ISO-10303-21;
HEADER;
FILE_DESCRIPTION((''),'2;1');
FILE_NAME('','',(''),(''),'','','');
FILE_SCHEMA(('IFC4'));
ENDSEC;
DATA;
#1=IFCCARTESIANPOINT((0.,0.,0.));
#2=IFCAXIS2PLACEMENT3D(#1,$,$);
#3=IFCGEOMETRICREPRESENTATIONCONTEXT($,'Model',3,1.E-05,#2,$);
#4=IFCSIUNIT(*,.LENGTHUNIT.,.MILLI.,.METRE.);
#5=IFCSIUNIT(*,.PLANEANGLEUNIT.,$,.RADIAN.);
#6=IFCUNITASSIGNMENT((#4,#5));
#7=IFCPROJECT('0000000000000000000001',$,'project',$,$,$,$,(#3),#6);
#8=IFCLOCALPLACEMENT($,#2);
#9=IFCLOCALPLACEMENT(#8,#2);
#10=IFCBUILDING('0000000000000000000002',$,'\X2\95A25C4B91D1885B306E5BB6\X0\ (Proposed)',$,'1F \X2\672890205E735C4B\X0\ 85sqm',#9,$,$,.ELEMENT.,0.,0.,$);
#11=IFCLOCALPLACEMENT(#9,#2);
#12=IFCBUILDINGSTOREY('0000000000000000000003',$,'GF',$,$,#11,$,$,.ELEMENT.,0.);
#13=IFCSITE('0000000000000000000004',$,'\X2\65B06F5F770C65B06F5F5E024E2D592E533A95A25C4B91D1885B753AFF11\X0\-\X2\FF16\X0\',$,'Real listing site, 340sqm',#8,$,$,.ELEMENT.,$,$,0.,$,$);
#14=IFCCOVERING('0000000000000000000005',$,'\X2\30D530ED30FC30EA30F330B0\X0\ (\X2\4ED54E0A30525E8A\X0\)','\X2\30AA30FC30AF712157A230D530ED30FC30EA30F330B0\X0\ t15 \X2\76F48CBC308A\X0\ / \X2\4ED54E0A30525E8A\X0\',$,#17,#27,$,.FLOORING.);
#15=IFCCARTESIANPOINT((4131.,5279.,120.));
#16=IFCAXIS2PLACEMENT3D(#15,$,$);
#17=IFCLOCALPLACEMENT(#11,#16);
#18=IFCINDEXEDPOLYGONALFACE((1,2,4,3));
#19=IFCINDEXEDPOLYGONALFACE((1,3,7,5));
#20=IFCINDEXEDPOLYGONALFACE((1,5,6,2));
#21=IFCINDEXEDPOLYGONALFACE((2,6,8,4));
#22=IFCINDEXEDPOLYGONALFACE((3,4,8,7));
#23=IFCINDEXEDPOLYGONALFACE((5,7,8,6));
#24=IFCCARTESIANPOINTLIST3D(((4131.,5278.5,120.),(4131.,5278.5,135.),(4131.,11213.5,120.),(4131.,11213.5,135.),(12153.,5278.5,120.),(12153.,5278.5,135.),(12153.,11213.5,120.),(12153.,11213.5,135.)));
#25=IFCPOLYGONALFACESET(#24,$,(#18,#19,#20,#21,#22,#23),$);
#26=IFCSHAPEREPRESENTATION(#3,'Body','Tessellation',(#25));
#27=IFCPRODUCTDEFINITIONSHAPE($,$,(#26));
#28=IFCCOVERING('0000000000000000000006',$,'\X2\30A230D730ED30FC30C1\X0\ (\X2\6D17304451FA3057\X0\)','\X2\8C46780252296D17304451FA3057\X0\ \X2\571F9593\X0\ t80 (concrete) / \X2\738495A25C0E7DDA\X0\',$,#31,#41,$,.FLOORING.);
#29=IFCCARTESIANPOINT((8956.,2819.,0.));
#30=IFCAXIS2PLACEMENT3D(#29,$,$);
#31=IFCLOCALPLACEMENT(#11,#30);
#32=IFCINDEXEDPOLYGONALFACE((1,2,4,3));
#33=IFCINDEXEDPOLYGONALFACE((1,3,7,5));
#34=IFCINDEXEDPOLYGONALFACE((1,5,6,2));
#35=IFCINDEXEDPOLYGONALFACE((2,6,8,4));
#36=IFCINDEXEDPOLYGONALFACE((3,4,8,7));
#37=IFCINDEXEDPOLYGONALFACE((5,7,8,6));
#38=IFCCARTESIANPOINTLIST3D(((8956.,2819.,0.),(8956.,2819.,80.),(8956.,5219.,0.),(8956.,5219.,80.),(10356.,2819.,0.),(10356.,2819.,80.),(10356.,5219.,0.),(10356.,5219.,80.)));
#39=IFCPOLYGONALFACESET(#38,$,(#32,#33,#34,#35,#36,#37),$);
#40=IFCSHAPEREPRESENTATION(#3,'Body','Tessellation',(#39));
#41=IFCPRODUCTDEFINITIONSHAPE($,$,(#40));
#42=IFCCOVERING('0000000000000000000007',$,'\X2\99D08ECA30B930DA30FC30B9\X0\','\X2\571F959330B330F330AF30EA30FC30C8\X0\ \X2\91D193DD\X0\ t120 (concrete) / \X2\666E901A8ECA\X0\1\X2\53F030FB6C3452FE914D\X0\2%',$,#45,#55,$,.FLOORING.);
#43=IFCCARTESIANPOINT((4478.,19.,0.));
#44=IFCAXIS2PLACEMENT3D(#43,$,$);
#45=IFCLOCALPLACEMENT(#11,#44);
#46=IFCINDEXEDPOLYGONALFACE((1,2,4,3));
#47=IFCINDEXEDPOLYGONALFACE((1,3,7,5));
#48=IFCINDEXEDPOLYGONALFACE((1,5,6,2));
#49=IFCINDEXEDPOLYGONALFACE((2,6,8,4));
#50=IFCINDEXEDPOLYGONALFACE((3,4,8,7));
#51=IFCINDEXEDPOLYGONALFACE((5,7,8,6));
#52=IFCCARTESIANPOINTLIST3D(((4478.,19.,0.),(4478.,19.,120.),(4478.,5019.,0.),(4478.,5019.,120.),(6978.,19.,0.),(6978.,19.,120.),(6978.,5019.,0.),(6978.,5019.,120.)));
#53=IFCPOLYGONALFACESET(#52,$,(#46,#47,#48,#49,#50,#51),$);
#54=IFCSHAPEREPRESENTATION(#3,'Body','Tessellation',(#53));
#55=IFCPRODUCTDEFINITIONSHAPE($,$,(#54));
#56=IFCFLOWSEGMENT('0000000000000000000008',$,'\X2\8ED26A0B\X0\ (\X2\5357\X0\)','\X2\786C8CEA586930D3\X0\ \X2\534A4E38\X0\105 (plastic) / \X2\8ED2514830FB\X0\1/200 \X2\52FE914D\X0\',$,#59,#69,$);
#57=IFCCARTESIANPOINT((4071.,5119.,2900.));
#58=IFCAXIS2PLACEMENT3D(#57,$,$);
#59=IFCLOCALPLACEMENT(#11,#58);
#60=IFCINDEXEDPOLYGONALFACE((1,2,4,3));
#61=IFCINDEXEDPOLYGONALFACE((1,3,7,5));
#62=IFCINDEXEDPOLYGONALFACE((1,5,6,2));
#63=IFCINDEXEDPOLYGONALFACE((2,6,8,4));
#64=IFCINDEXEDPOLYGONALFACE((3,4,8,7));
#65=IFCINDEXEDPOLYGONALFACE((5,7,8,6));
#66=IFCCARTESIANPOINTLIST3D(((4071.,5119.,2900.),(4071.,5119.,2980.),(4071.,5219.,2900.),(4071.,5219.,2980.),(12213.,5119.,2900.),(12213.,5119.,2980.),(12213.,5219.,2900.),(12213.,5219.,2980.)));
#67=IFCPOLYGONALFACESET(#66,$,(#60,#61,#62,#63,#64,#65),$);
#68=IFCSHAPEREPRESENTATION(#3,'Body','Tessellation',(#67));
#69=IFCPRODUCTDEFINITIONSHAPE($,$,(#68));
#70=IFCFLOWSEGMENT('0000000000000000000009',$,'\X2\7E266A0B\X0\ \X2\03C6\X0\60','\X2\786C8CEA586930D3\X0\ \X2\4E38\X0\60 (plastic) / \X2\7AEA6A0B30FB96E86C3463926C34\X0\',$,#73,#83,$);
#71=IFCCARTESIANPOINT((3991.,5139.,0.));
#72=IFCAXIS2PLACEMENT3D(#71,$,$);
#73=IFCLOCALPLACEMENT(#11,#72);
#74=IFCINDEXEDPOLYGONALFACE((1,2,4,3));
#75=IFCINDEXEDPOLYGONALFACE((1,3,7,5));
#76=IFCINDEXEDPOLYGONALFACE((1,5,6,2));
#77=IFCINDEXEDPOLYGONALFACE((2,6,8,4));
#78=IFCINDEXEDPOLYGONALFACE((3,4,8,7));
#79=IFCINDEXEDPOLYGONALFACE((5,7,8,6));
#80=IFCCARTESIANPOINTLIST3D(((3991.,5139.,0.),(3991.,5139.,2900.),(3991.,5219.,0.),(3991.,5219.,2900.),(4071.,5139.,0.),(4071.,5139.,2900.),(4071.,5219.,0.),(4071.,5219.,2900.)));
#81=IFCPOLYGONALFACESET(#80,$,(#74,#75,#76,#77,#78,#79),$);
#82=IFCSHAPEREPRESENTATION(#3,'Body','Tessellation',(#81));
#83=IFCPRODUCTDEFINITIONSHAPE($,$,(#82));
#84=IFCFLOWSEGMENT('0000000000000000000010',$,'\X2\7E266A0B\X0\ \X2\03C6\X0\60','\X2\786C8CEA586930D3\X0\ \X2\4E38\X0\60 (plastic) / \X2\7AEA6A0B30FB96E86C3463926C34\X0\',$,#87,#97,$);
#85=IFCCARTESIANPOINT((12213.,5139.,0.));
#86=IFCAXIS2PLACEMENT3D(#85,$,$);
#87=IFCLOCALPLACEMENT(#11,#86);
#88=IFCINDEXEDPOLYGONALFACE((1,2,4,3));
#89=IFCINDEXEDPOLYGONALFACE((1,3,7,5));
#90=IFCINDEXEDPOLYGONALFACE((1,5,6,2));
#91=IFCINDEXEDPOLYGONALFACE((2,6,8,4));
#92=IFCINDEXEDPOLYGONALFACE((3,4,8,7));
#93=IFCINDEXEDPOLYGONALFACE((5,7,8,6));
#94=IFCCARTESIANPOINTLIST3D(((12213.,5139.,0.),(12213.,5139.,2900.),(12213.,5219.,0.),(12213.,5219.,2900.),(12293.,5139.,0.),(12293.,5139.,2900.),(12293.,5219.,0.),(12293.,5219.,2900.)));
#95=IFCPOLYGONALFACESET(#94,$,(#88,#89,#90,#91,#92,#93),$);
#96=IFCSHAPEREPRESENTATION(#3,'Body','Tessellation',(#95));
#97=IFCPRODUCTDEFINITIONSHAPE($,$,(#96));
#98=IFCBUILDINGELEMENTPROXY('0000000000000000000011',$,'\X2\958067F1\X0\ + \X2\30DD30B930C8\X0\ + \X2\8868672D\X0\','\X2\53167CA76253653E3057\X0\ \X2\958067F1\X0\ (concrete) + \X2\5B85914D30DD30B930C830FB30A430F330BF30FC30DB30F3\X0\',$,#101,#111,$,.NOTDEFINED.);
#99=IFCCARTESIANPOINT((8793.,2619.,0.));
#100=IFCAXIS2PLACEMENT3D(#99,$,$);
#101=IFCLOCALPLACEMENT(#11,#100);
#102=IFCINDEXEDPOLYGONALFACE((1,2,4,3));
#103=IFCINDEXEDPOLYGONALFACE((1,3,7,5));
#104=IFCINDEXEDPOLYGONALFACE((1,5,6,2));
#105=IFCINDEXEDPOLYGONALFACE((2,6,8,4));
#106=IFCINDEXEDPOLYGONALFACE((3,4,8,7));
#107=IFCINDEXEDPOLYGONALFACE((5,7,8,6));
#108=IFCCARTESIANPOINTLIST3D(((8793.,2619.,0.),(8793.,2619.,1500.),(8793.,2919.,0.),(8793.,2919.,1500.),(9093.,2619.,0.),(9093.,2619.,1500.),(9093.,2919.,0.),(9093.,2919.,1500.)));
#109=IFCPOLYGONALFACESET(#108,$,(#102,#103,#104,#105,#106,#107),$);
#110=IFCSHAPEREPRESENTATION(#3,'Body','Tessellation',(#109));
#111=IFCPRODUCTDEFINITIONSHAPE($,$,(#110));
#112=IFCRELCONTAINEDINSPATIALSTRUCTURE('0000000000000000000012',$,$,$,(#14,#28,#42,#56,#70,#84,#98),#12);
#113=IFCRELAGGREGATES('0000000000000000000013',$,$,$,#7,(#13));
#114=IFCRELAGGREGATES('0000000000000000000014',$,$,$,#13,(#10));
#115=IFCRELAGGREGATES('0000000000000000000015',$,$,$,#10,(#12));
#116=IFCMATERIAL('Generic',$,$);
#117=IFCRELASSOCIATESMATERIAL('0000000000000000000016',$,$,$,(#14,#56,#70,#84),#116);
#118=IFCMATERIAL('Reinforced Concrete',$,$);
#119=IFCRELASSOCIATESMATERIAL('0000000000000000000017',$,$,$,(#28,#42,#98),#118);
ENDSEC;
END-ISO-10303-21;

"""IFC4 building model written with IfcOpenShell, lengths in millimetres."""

from ifc_helpers import new_model, si_unit, frame, frame_2d, origin, place, context, project, spatial, rectangle, extrude, material, element, save


model = new_model("IFC4")

# Units and contexts
model_context = context("Model", 3, precision=1e-05, world=origin())
ifc_project = project(units=[si_unit("LENGTHUNIT", "METRE", prefix="MILLI"), si_unit("PLANEANGLEUNIT", "RADIAN")], contexts=[model_context])

# Site, building, storey
site_placement = place(None, origin())
site = spatial("IfcSite", under=ifc_project, at=site_placement, Name="新潟県新潟市中央区関屋金衛町１-６", ObjectType="Real listing site, 340sqm", CompositionType="ELEMENT", RefElevation=0.0)
building_placement = place(site_placement, origin())
building = spatial("IfcBuilding", under=site, at=building_placement, Name="関屋金衛の家 (Proposed)", ObjectType="1F 木造平屋 85sqm", CompositionType="ELEMENT", ElevationOfRefHeight=0.0, ElevationOfTerrain=0.0)
storey_placement = place(building_placement, origin())
storey = spatial("IfcBuildingStorey", under=building, at=storey_placement, Name="GF", CompositionType="ELEMENT", Elevation=0.0)

# Shared definitions
ifc_material_1 = material(Name="Reinforced Concrete")

# Coverings
ifc_material_2 = material(Name="Generic")
covering_1_placement = place(storey_placement, frame((4131.0, 5279.0, 120.0)))
element("IfcCovering", 1, at=covering_1_placement, inside=storey, material=ifc_material_2, Name="フローリング (仕上げ床)", Description="オーク無垢フローリング t15 直貼り / 仕上げ床", PredefinedType="FLOORING", context=model_context, shape_type="SweptSolid", body=[
    extrude(rectangle(XDim=8022.0, YDim=5935.0, at=frame_2d((4011.0, 2967.0))), frame((4131.0, 5279.0, 120.0)), (0.0, 0.0, 1.0), 15.0),
])
covering_2_placement = place(storey_placement, frame((8956.0, 2819.0, 0.0)))
element("IfcCovering", 2, at=covering_2_placement, inside=storey, material=ifc_material_1, Name="アプローチ (洗い出し)", Description="豆砂利洗い出し 土間 t80 (concrete) / 玄関導線", PredefinedType="FLOORING", context=model_context, shape_type="SweptSolid", body=[
    extrude(rectangle(XDim=1400.0, YDim=2400.0, at=frame_2d((700.0, 1200.0))), frame((8956.0, 2819.0, 0.0)), (0.0, 0.0, 1.0), 80.0),
])
covering_3_placement = place(storey_placement, frame((4478.0, 19.0, 0.0)))
element("IfcCovering", 3, at=covering_3_placement, inside=storey, material=ifc_material_1, Name="駐車スペース", Description="土間コンクリート 金鏝 t120 (concrete) / 普通車1台・水勾配2%", PredefinedType="FLOORING", context=model_context, shape_type="SweptSolid", body=[
    extrude(rectangle(XDim=2500.0, YDim=5000.0, at=frame_2d((1250.0, 2500.0))), frame((4478.0, 19.0, 0.0)), (0.0, 0.0, 1.0), 120.0),
])

# Flow segments
flow_segment_1_placement = place(storey_placement, frame((4071.0, 5119.0, 2900.0)))
element("IfcFlowSegment", 4, at=flow_segment_1_placement, inside=storey, material=ifc_material_2, Name="軒樋 (南)", Description="硬質塩ビ 半丸105 (plastic) / 軒先・1/200 勾配", context=model_context, shape_type="SweptSolid", body=[
    extrude(rectangle(XDim=8142.0, YDim=100.0, at=frame_2d((4071.0, 50.0))), frame((4071.0, 5119.0, 2900.0)), (0.0, 0.0, 1.0), 80.0),
])
flow_segment_2_placement = place(storey_placement, frame((3991.0, 5139.0, 0.0)))
element("IfcFlowSegment", 5, at=flow_segment_2_placement, inside=storey, material=ifc_material_2, Name="縦樋 φ60", Description="硬質塩ビ 丸60 (plastic) / 竪樋・雨水排水", context=model_context, shape_type="SweptSolid", body=[
    extrude(rectangle(XDim=80.0, YDim=80.0, at=frame_2d((40.0, 40.0))), frame((3991.0, 5139.0, 0.0)), (0.0, 0.0, 1.0), 2900.0),
])
flow_segment_3_placement = place(storey_placement, frame((12213.0, 5139.0, 0.0)))
element("IfcFlowSegment", 6, at=flow_segment_3_placement, inside=storey, material=ifc_material_2, Name="縦樋 φ60", Description="硬質塩ビ 丸60 (plastic) / 竪樋・雨水排水", context=model_context, shape_type="SweptSolid", body=[
    extrude(rectangle(XDim=80.0, YDim=80.0, at=frame_2d((40.0, 40.0))), frame((12213.0, 5139.0, 0.0)), (0.0, 0.0, 1.0), 2900.0),
])

# Building element proxy
proxy_placement = place(storey_placement, frame((8793.0, 2619.0, 0.0)))
element("IfcBuildingElementProxy", 7, at=proxy_placement, inside=storey, material=ifc_material_1, Name="門柱 + ポスト + 表札", Description="化粧打放し 門柱 (concrete) + 宅配ポスト・インターホン", PredefinedType="NOTDEFINED", context=model_context, shape_type="SweptSolid", body=[
    extrude(rectangle(XDim=300.0, YDim=300.0, at=frame_2d((150.0, 150.0))), frame((8793.0, 2619.0, 0.0)), (0.0, 0.0, 1.0), 1500.0),
])

save(model, "model.ifc")
